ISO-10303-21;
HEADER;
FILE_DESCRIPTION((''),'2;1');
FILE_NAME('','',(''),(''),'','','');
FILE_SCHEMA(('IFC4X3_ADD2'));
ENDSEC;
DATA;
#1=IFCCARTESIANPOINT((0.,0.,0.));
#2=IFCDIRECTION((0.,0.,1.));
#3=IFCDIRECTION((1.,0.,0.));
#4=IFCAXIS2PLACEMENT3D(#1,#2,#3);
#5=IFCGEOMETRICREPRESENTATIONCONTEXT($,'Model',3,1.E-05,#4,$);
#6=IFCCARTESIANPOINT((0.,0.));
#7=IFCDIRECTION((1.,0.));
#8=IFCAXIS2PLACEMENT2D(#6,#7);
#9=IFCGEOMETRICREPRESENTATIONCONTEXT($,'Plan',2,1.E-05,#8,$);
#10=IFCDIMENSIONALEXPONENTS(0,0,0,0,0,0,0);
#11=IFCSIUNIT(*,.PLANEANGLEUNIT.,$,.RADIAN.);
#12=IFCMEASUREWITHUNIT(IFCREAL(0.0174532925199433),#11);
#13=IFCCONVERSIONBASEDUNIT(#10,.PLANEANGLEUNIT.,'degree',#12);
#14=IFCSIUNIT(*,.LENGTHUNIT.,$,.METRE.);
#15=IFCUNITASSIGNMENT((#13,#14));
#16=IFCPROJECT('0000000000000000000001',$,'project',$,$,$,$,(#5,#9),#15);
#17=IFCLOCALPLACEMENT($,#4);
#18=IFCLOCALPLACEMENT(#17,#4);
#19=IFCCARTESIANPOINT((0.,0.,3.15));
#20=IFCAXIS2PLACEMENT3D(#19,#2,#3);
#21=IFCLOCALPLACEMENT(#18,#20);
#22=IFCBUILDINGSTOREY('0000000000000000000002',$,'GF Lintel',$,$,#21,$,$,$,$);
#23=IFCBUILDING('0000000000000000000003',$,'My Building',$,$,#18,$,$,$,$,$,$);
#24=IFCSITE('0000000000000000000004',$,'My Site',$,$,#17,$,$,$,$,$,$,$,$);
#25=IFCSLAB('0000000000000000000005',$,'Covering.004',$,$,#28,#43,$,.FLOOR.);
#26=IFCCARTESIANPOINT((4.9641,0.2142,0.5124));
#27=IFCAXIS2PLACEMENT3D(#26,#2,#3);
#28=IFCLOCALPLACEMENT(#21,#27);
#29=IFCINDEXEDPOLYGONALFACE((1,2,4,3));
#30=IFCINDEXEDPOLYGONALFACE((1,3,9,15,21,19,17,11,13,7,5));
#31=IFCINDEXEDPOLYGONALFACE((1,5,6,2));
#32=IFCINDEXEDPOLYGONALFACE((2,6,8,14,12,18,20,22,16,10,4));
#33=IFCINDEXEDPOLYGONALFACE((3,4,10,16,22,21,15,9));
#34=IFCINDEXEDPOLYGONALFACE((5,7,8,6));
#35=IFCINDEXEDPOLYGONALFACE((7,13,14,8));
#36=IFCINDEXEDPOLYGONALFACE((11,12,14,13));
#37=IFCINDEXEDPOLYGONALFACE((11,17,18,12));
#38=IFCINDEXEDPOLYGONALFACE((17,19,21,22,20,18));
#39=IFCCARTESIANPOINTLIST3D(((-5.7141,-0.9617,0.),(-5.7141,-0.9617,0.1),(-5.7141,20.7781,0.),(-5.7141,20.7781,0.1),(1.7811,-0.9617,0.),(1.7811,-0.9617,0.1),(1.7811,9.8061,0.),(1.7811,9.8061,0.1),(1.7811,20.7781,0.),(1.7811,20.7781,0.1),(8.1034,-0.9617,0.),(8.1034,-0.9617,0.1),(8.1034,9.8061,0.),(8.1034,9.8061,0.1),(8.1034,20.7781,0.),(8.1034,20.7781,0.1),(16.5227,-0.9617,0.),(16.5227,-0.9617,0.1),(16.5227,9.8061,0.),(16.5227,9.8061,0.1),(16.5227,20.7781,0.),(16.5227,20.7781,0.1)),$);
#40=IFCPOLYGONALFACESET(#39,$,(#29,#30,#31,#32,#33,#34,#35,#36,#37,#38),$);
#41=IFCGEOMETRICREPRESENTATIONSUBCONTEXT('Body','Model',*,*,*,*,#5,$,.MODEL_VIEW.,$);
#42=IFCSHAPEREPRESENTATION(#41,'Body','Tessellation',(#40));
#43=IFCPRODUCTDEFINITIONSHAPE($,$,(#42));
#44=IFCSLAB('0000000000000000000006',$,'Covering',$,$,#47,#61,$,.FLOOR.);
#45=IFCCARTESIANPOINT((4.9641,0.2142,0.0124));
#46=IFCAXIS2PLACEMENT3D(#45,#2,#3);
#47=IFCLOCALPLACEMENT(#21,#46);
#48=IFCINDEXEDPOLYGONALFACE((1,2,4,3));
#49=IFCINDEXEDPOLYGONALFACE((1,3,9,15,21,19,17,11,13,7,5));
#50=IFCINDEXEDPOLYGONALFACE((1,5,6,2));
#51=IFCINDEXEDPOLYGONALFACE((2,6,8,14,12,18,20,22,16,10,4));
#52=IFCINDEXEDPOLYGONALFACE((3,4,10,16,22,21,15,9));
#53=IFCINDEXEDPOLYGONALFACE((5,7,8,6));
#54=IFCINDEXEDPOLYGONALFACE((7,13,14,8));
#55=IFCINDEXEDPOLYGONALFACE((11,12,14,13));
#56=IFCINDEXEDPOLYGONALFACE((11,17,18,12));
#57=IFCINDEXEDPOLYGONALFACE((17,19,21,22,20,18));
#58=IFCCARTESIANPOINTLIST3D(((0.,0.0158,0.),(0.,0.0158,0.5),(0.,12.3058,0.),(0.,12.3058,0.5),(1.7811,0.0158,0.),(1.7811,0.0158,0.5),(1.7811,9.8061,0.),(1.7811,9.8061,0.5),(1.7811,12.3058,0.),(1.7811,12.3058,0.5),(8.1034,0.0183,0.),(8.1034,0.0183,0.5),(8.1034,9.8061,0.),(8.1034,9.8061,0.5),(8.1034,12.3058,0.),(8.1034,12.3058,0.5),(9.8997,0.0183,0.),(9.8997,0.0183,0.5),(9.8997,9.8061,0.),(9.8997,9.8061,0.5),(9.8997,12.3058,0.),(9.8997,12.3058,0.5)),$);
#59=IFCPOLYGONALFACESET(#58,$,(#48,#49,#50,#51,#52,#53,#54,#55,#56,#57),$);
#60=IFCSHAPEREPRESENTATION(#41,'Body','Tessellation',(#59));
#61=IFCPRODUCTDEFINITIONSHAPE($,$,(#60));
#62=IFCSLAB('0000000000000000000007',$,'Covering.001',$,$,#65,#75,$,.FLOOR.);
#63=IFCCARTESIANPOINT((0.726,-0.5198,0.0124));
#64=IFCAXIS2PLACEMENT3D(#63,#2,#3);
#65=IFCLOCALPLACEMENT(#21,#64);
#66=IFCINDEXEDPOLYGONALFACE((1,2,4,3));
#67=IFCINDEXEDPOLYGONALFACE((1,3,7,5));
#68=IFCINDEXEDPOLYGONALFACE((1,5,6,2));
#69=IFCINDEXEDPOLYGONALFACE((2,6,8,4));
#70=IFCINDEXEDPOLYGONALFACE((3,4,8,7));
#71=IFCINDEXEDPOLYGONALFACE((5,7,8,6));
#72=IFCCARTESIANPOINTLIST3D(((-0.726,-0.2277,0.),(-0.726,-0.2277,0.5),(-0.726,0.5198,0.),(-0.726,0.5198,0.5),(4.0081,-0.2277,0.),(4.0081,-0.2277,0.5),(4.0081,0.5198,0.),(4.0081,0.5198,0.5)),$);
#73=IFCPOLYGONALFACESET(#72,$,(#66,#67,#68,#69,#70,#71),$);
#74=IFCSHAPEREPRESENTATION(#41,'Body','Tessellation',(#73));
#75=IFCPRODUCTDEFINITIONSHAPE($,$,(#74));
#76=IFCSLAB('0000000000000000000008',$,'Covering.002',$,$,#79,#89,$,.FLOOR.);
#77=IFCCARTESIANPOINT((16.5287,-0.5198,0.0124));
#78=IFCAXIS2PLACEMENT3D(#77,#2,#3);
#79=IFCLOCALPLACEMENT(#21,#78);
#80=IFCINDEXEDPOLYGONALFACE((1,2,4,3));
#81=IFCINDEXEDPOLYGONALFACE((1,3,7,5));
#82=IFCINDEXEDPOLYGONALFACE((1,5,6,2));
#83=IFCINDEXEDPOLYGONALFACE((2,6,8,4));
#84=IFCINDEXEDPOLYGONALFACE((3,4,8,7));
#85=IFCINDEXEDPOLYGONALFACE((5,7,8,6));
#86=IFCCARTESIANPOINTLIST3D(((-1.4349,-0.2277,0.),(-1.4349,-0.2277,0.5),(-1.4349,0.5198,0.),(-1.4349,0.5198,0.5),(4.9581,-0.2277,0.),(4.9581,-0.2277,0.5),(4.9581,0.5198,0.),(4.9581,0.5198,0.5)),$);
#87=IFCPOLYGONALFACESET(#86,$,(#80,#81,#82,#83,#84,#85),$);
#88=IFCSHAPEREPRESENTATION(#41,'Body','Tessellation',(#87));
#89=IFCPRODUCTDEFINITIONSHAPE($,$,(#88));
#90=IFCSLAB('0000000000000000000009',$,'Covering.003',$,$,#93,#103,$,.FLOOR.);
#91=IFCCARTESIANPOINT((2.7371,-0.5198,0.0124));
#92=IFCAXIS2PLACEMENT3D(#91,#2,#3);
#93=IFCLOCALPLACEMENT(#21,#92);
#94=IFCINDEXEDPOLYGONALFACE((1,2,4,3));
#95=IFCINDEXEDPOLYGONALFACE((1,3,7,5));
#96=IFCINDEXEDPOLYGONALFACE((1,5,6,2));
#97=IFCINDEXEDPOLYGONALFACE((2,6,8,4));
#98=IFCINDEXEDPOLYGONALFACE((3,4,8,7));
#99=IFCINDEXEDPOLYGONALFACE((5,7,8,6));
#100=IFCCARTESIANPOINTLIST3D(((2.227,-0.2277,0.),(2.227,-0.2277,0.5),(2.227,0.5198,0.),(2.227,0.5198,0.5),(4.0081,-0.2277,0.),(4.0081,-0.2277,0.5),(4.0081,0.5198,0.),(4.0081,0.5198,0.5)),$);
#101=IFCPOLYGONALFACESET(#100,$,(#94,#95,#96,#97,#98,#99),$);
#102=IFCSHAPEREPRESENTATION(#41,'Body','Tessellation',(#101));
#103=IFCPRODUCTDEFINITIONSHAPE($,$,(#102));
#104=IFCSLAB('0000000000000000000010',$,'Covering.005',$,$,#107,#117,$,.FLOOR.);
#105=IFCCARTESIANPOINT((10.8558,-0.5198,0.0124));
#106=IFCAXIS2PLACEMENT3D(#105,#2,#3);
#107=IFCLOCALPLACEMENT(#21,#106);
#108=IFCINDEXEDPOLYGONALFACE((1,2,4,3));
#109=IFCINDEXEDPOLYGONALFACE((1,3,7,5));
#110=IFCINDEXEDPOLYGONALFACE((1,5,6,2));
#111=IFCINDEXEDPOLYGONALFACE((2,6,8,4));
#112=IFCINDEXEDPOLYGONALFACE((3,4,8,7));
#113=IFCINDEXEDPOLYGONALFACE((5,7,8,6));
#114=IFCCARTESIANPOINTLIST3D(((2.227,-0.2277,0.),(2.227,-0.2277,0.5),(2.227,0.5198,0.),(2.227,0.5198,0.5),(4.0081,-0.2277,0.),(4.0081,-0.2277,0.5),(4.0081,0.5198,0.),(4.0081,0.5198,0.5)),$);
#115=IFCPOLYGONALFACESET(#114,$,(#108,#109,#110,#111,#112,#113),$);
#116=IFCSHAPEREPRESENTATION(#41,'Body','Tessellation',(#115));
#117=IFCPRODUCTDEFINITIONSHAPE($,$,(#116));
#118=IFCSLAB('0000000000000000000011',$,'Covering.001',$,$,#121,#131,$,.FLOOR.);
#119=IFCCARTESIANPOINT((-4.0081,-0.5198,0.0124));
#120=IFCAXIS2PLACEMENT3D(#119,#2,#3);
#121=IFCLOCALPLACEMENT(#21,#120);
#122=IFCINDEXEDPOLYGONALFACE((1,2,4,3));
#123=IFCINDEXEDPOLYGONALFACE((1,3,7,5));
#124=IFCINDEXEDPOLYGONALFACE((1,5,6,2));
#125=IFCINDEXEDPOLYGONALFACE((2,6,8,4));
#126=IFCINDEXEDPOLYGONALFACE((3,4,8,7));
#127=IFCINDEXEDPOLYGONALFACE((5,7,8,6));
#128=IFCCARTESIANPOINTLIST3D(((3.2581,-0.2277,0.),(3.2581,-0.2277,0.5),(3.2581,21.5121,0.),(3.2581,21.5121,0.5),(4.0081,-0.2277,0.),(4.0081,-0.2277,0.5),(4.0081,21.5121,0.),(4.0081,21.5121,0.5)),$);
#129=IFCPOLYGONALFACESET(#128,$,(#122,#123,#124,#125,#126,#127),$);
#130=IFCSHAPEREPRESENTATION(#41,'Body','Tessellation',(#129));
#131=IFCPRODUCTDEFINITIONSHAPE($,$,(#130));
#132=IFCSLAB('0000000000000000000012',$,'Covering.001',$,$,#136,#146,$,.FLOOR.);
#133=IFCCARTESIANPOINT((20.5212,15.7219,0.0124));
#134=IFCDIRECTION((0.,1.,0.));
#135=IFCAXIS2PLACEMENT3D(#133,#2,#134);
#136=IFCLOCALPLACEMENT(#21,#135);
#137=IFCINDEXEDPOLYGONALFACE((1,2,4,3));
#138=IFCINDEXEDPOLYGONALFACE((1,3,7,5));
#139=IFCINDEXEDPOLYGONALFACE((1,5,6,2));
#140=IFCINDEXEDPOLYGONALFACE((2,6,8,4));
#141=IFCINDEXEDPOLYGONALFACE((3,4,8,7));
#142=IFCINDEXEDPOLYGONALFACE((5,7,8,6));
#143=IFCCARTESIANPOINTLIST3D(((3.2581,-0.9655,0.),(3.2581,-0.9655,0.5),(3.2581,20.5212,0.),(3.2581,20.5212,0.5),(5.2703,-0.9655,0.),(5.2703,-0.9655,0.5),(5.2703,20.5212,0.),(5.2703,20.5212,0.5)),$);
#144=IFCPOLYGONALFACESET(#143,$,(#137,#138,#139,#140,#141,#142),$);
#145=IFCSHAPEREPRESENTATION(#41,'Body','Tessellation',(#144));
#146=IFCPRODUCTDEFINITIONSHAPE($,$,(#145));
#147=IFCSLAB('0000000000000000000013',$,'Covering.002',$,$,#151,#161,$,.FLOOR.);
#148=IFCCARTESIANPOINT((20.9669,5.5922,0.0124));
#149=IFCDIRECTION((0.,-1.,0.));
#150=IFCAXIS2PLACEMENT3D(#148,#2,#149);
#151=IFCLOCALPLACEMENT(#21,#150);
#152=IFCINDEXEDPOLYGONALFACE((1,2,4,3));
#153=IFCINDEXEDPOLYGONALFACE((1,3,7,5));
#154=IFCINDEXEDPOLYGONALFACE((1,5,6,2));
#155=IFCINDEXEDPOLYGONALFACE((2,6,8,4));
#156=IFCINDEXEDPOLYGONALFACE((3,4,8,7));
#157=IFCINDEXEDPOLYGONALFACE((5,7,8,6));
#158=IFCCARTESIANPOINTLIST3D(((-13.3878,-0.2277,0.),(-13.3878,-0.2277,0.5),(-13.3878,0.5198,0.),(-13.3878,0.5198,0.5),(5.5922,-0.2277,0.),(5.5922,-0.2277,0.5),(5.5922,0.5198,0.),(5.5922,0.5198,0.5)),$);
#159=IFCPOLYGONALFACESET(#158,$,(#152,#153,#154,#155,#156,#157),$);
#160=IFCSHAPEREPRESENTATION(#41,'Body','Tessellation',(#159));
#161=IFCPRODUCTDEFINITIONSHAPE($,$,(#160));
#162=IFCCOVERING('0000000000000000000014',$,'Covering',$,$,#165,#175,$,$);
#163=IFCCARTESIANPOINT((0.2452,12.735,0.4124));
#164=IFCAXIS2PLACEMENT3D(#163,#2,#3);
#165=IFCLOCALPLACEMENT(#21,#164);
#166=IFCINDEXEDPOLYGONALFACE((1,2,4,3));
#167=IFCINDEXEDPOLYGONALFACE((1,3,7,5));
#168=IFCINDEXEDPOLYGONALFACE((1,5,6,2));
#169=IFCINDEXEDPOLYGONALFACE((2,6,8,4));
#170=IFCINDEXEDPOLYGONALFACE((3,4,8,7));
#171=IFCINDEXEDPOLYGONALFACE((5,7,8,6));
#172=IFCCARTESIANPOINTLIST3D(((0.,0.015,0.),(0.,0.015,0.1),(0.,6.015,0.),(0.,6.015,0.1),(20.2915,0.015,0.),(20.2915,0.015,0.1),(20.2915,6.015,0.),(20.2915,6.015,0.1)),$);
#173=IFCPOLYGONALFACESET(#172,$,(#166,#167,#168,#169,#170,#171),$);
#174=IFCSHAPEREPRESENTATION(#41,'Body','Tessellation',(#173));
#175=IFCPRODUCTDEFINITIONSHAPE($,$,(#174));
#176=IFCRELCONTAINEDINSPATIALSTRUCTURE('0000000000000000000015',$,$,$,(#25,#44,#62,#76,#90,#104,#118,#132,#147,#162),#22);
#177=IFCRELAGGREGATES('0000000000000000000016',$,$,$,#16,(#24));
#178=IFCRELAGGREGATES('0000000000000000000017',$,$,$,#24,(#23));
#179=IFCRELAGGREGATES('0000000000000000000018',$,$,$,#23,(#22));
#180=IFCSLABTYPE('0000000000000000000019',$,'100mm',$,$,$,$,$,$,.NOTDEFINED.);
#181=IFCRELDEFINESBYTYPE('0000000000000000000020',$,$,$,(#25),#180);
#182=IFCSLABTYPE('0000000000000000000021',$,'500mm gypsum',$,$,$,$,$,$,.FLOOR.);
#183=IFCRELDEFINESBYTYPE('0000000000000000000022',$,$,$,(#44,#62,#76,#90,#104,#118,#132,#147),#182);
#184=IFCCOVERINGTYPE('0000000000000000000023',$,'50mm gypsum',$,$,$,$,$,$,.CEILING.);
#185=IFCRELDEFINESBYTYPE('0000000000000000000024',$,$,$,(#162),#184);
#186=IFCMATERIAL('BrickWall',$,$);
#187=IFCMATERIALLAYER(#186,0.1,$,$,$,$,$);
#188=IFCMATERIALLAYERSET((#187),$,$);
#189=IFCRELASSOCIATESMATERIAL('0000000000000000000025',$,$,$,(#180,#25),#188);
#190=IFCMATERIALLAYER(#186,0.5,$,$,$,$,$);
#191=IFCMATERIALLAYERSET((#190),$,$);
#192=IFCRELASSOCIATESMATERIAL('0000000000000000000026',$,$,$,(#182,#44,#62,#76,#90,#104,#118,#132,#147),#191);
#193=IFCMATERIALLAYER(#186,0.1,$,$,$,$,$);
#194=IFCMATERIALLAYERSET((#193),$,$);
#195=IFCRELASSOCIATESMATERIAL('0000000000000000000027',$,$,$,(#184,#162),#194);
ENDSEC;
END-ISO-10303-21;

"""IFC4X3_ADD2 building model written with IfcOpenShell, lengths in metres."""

from ifc_helpers import new_model, entity, si_unit, converted_unit, frame, origin_with_axes, origin_2d_with_axis, place, context, subcontext, project, spatial, line, indexed_curve, outline, extrude, material, layer, layer_set, layer_usage, type_object, element, save


model = new_model("IFC4X3_ADD2")

# Units and contexts
model_context = context("Model", 3, precision=1e-05, world=origin_with_axes())
plan_context = context("Plan", 2, precision=1e-05, world=origin_2d_with_axis())
body_context = subcontext(model_context, "Body", "Model", "MODEL_VIEW")
ifc_project = project(units=[converted_unit("PLANEANGLEUNIT", "degree", entity("IfcReal", 0.0174532925199433), si_unit("PLANEANGLEUNIT", "RADIAN"), dimensions=[0, 0, 0, 0, 0, 0, 0]), si_unit("LENGTHUNIT", "METRE")], contexts=[model_context, plan_context])

# Site, building, storey
site_placement = place(None, origin_with_axes())
site = spatial("IfcSite", under=ifc_project, at=site_placement, Name="My Site")
building_placement = place(site_placement, origin_with_axes())
building = spatial("IfcBuilding", under=site, at=building_placement, Name="My Building")
storey_placement = place(building_placement, frame((0.0, 0.0, 3.15), z_axis=(0.0, 0.0, 1.0), x_axis=(1.0, 0.0, 0.0)))
storey = spatial("IfcBuildingStorey", under=building, at=storey_placement, Name="GF Lintel")

# Slabs
ifc_material = material(Name="BrickWall")
ifc_layer_1 = layer(ifc_material, 0.1)
ifc_layer_set_1 = layer_set([ifc_layer_1])
ifc_layer_usage_1 = layer_usage(ifc_layer_set_1, "AXIS3", "POSITIVE", 0.0)
slab_type_1 = type_object("IfcSlabType", Name="100mm", PredefinedType="NOTDEFINED", material=ifc_layer_set_1)
slab_1_placement = place(storey_placement, frame((4.9641, 0.2142, 0.5124), z_axis=(0.0, 0.0, 1.0), x_axis=(1.0, 0.0, 0.0)))
element("IfcSlab", 1, at=slab_1_placement, inside=storey, type_object=slab_type_1, material=ifc_layer_usage_1, Name="Covering.004", PredefinedType="FLOOR", context=body_context, shape_type="SweptSolid", body=[
    extrude(outline(indexed_curve([(8.1034, 9.8061), (1.7811, 9.8061), (1.7811, -0.9617), (-5.7141, -0.9617), (-5.7141, 20.7781), (1.7811, 20.7781), (8.1034, 20.7781), (16.5227, 20.7781), (16.5227, 9.8061), (16.5227, -0.9617), (8.1034, -0.9617)], segments=[line(7, 6), line(6, 5), line(5, 4), line(4, 3), line(3, 2), line(2, 1), line(1, 11), line(11, 10), line(10, 9), line(9, 8), line(8, 7)], self_intersect=False)), None, (0.0, 0.0, 1.0), 0.1),
])
ifc_layer_2 = layer(ifc_material, 0.5)
ifc_layer_set_2 = layer_set([ifc_layer_2])
ifc_layer_usage_2 = layer_usage(ifc_layer_set_2, "AXIS3", "POSITIVE", 0.0)
slab_type_2 = type_object("IfcSlabType", Name="500mm gypsum", PredefinedType="FLOOR", material=ifc_layer_set_2)
slab_2_placement = place(storey_placement, frame((4.9641, 0.2142, 0.0124), z_axis=(0.0, 0.0, 1.0), x_axis=(1.0, 0.0, 0.0)))
element("IfcSlab", 2, at=slab_2_placement, inside=storey, type_object=slab_type_2, material=ifc_layer_usage_2, Name="Covering", PredefinedType="FLOOR", context=body_context, shape_type="SweptSolid", body=[
    extrude(outline(indexed_curve([(8.1034, 12.3058), (9.8997, 12.3058), (9.8997, 9.8061), (9.8997, 0.0183), (8.1034, 0.0183), (8.1034, 9.8061), (1.7811, 9.8061), (1.7811, 0.0158), (0.0, 0.0158), (0.0, 12.3058), (1.7811, 12.3058)], segments=[line(5, 4), line(4, 3), line(3, 2), line(2, 1), line(1, 11), line(11, 10), line(10, 9), line(9, 8), line(8, 7), line(7, 6), line(6, 5)], self_intersect=False)), None, (0.0, 0.0, 1.0), 0.5),
])
ifc_layer_usage_3 = layer_usage(ifc_layer_set_2, "AXIS3", "POSITIVE", 0.0)
slab_3_placement = place(storey_placement, frame((0.726, -0.5198, 0.0124), z_axis=(0.0, 0.0, 1.0), x_axis=(1.0, 0.0, 0.0)))
element("IfcSlab", 3, at=slab_3_placement, inside=storey, type_object=slab_type_2, material=ifc_layer_usage_3, Name="Covering.001", PredefinedType="FLOOR", context=body_context, shape_type="SweptSolid", body=[
    extrude(outline(indexed_curve([(4.0081, -0.2277), (-0.726, -0.2277), (-0.726, 0.5198), (4.0081, 0.5198)], segments=[line(3, 2), line(2, 1), line(1, 4), line(4, 3)], self_intersect=False)), None, (0.0, 0.0, 1.0), 0.5),
])
ifc_layer_usage_4 = layer_usage(ifc_layer_set_2, "AXIS3", "POSITIVE", 0.0)
slab_4_placement = place(storey_placement, frame((16.5287, -0.5198, 0.0124), z_axis=(0.0, 0.0, 1.0), x_axis=(1.0, 0.0, 0.0)))
element("IfcSlab", 4, at=slab_4_placement, inside=storey, type_object=slab_type_2, material=ifc_layer_usage_4, Name="Covering.002", PredefinedType="FLOOR", context=body_context, shape_type="SweptSolid", body=[
    extrude(outline(indexed_curve([(4.9581, 0.5198), (4.9581, -0.2277), (-1.4349, -0.2277), (-1.4349, 0.5198)], segments=[line(3, 2), line(2, 1), line(1, 4), line(4, 3)], self_intersect=False)), None, (0.0, 0.0, 1.0), 0.5),
])
ifc_layer_usage_5 = layer_usage(ifc_layer_set_2, "AXIS3", "POSITIVE", 0.0)
slab_5_placement = place(storey_placement, frame((2.7371, -0.5198, 0.0124), z_axis=(0.0, 0.0, 1.0), x_axis=(1.0, 0.0, 0.0)))
element("IfcSlab", 5, at=slab_5_placement, inside=storey, type_object=slab_type_2, material=ifc_layer_usage_5, Name="Covering.003", PredefinedType="FLOOR", context=body_context, shape_type="SweptSolid", body=[
    extrude(outline(indexed_curve([(4.0081, -0.2277), (2.227, -0.2277), (2.227, 0.5198), (4.0081, 0.5198)], segments=[line(4, 1), line(1, 2), line(2, 3), line(3, 4)], self_intersect=False)), None, (0.0, 0.0, 1.0), 0.5),
])
ifc_layer_usage_6 = layer_usage(ifc_layer_set_2, "AXIS3", "POSITIVE", 0.0)
slab_6_placement = place(storey_placement, frame((10.8558, -0.5198, 0.0124), z_axis=(0.0, 0.0, 1.0), x_axis=(1.0, 0.0, 0.0)))
element("IfcSlab", 6, at=slab_6_placement, inside=storey, type_object=slab_type_2, material=ifc_layer_usage_6, Name="Covering.005", PredefinedType="FLOOR", context=body_context, shape_type="SweptSolid", body=[
    extrude(outline(indexed_curve([(4.0081, 0.5198), (4.0081, -0.2277), (2.227, -0.2277), (2.227, 0.5198)], segments=[line(3, 2), line(2, 1), line(1, 4), line(4, 3)], self_intersect=False)), None, (0.0, 0.0, 1.0), 0.5),
])
ifc_layer_usage_7 = layer_usage(ifc_layer_set_2, "AXIS3", "POSITIVE", 0.0)
slab_7_placement = place(storey_placement, frame((-4.0081, -0.5198, 0.0124), z_axis=(0.0, 0.0, 1.0), x_axis=(1.0, 0.0, 0.0)))
element("IfcSlab", 7, at=slab_7_placement, inside=storey, type_object=slab_type_2, material=ifc_layer_usage_7, Name="Covering.001", PredefinedType="FLOOR", context=body_context, shape_type="SweptSolid", body=[
    extrude(outline(indexed_curve([(3.2581, 21.5121), (3.2581, -0.2277), (4.0081, -0.2277), (4.0081, 21.5121)], segments=[line(3, 2), line(2, 1), line(1, 4), line(4, 3)], self_intersect=False)), None, (0.0, 0.0, 1.0), 0.5),
])
ifc_layer_usage_8 = layer_usage(ifc_layer_set_2, "AXIS3", "POSITIVE", 0.0)
slab_8_placement = place(storey_placement, frame((20.5212, 15.7219, 0.0124), z_axis=(0.0, 0.0, 1.0), x_axis=(0.0, 1.0, 0.0)))
element("IfcSlab", 8, at=slab_8_placement, inside=storey, type_object=slab_type_2, material=ifc_layer_usage_8, Name="Covering.001", PredefinedType="FLOOR", context=body_context, shape_type="SweptSolid", body=[
    extrude(outline(indexed_curve([(5.2703, 20.5212), (3.2581, 20.5212), (3.2581, -0.9655), (5.2703, -0.9655)], segments=[line(4, 1), line(1, 2), line(2, 3), line(3, 4)], self_intersect=False)), None, (0.0, 0.0, 1.0), 0.5),
])
ifc_layer_usage_9 = layer_usage(ifc_layer_set_2, "AXIS3", "POSITIVE", 0.0)
slab_9_placement = place(storey_placement, frame((20.9669, 5.5922, 0.0124), z_axis=(0.0, 0.0, 1.0), x_axis=(0.0, -1.0, 0.0)))
element("IfcSlab", 9, at=slab_9_placement, inside=storey, type_object=slab_type_2, material=ifc_layer_usage_9, Name="Covering.002", PredefinedType="FLOOR", context=body_context, shape_type="SweptSolid", body=[
    extrude(outline(indexed_curve([(-13.3878, -0.2277), (5.5922, -0.2277), (5.5922, 0.5198), (-13.3878, 0.5198)], segments=[line(3, 2), line(2, 1), line(1, 4), line(4, 3)], self_intersect=False)), None, (0.0, 0.0, 1.0), 0.5),
])

# Covering
ifc_layer_3 = layer(ifc_material, 0.1)
ifc_layer_set_3 = layer_set([ifc_layer_3])
ifc_layer_usage_10 = layer_usage(ifc_layer_set_3, "AXIS3", "POSITIVE", 0.0)
covering_type = type_object("IfcCoveringType", Name="50mm gypsum", PredefinedType="CEILING", material=ifc_layer_set_3)
covering_1_placement = place(storey_placement, frame((0.2452, 12.735, 0.4124), z_axis=(0.0, 0.0, 1.0), x_axis=(1.0, 0.0, 0.0)))
element("IfcCovering", 10, at=covering_1_placement, inside=storey, type_object=covering_type, material=ifc_layer_usage_10, Name="Covering", context=body_context, shape_type="SweptSolid", body=[
    extrude(outline(indexed_curve([(0.0, 6.015), (0.0, 0.015), (20.2915, 0.015), (20.2915, 6.015)], segments=[line(4, 1), line(1, 2), line(2, 3), line(3, 4)], self_intersect=False)), None, (0.0, 0.0, 1.0), 0.1),
])

save(model, "model.ifc")
